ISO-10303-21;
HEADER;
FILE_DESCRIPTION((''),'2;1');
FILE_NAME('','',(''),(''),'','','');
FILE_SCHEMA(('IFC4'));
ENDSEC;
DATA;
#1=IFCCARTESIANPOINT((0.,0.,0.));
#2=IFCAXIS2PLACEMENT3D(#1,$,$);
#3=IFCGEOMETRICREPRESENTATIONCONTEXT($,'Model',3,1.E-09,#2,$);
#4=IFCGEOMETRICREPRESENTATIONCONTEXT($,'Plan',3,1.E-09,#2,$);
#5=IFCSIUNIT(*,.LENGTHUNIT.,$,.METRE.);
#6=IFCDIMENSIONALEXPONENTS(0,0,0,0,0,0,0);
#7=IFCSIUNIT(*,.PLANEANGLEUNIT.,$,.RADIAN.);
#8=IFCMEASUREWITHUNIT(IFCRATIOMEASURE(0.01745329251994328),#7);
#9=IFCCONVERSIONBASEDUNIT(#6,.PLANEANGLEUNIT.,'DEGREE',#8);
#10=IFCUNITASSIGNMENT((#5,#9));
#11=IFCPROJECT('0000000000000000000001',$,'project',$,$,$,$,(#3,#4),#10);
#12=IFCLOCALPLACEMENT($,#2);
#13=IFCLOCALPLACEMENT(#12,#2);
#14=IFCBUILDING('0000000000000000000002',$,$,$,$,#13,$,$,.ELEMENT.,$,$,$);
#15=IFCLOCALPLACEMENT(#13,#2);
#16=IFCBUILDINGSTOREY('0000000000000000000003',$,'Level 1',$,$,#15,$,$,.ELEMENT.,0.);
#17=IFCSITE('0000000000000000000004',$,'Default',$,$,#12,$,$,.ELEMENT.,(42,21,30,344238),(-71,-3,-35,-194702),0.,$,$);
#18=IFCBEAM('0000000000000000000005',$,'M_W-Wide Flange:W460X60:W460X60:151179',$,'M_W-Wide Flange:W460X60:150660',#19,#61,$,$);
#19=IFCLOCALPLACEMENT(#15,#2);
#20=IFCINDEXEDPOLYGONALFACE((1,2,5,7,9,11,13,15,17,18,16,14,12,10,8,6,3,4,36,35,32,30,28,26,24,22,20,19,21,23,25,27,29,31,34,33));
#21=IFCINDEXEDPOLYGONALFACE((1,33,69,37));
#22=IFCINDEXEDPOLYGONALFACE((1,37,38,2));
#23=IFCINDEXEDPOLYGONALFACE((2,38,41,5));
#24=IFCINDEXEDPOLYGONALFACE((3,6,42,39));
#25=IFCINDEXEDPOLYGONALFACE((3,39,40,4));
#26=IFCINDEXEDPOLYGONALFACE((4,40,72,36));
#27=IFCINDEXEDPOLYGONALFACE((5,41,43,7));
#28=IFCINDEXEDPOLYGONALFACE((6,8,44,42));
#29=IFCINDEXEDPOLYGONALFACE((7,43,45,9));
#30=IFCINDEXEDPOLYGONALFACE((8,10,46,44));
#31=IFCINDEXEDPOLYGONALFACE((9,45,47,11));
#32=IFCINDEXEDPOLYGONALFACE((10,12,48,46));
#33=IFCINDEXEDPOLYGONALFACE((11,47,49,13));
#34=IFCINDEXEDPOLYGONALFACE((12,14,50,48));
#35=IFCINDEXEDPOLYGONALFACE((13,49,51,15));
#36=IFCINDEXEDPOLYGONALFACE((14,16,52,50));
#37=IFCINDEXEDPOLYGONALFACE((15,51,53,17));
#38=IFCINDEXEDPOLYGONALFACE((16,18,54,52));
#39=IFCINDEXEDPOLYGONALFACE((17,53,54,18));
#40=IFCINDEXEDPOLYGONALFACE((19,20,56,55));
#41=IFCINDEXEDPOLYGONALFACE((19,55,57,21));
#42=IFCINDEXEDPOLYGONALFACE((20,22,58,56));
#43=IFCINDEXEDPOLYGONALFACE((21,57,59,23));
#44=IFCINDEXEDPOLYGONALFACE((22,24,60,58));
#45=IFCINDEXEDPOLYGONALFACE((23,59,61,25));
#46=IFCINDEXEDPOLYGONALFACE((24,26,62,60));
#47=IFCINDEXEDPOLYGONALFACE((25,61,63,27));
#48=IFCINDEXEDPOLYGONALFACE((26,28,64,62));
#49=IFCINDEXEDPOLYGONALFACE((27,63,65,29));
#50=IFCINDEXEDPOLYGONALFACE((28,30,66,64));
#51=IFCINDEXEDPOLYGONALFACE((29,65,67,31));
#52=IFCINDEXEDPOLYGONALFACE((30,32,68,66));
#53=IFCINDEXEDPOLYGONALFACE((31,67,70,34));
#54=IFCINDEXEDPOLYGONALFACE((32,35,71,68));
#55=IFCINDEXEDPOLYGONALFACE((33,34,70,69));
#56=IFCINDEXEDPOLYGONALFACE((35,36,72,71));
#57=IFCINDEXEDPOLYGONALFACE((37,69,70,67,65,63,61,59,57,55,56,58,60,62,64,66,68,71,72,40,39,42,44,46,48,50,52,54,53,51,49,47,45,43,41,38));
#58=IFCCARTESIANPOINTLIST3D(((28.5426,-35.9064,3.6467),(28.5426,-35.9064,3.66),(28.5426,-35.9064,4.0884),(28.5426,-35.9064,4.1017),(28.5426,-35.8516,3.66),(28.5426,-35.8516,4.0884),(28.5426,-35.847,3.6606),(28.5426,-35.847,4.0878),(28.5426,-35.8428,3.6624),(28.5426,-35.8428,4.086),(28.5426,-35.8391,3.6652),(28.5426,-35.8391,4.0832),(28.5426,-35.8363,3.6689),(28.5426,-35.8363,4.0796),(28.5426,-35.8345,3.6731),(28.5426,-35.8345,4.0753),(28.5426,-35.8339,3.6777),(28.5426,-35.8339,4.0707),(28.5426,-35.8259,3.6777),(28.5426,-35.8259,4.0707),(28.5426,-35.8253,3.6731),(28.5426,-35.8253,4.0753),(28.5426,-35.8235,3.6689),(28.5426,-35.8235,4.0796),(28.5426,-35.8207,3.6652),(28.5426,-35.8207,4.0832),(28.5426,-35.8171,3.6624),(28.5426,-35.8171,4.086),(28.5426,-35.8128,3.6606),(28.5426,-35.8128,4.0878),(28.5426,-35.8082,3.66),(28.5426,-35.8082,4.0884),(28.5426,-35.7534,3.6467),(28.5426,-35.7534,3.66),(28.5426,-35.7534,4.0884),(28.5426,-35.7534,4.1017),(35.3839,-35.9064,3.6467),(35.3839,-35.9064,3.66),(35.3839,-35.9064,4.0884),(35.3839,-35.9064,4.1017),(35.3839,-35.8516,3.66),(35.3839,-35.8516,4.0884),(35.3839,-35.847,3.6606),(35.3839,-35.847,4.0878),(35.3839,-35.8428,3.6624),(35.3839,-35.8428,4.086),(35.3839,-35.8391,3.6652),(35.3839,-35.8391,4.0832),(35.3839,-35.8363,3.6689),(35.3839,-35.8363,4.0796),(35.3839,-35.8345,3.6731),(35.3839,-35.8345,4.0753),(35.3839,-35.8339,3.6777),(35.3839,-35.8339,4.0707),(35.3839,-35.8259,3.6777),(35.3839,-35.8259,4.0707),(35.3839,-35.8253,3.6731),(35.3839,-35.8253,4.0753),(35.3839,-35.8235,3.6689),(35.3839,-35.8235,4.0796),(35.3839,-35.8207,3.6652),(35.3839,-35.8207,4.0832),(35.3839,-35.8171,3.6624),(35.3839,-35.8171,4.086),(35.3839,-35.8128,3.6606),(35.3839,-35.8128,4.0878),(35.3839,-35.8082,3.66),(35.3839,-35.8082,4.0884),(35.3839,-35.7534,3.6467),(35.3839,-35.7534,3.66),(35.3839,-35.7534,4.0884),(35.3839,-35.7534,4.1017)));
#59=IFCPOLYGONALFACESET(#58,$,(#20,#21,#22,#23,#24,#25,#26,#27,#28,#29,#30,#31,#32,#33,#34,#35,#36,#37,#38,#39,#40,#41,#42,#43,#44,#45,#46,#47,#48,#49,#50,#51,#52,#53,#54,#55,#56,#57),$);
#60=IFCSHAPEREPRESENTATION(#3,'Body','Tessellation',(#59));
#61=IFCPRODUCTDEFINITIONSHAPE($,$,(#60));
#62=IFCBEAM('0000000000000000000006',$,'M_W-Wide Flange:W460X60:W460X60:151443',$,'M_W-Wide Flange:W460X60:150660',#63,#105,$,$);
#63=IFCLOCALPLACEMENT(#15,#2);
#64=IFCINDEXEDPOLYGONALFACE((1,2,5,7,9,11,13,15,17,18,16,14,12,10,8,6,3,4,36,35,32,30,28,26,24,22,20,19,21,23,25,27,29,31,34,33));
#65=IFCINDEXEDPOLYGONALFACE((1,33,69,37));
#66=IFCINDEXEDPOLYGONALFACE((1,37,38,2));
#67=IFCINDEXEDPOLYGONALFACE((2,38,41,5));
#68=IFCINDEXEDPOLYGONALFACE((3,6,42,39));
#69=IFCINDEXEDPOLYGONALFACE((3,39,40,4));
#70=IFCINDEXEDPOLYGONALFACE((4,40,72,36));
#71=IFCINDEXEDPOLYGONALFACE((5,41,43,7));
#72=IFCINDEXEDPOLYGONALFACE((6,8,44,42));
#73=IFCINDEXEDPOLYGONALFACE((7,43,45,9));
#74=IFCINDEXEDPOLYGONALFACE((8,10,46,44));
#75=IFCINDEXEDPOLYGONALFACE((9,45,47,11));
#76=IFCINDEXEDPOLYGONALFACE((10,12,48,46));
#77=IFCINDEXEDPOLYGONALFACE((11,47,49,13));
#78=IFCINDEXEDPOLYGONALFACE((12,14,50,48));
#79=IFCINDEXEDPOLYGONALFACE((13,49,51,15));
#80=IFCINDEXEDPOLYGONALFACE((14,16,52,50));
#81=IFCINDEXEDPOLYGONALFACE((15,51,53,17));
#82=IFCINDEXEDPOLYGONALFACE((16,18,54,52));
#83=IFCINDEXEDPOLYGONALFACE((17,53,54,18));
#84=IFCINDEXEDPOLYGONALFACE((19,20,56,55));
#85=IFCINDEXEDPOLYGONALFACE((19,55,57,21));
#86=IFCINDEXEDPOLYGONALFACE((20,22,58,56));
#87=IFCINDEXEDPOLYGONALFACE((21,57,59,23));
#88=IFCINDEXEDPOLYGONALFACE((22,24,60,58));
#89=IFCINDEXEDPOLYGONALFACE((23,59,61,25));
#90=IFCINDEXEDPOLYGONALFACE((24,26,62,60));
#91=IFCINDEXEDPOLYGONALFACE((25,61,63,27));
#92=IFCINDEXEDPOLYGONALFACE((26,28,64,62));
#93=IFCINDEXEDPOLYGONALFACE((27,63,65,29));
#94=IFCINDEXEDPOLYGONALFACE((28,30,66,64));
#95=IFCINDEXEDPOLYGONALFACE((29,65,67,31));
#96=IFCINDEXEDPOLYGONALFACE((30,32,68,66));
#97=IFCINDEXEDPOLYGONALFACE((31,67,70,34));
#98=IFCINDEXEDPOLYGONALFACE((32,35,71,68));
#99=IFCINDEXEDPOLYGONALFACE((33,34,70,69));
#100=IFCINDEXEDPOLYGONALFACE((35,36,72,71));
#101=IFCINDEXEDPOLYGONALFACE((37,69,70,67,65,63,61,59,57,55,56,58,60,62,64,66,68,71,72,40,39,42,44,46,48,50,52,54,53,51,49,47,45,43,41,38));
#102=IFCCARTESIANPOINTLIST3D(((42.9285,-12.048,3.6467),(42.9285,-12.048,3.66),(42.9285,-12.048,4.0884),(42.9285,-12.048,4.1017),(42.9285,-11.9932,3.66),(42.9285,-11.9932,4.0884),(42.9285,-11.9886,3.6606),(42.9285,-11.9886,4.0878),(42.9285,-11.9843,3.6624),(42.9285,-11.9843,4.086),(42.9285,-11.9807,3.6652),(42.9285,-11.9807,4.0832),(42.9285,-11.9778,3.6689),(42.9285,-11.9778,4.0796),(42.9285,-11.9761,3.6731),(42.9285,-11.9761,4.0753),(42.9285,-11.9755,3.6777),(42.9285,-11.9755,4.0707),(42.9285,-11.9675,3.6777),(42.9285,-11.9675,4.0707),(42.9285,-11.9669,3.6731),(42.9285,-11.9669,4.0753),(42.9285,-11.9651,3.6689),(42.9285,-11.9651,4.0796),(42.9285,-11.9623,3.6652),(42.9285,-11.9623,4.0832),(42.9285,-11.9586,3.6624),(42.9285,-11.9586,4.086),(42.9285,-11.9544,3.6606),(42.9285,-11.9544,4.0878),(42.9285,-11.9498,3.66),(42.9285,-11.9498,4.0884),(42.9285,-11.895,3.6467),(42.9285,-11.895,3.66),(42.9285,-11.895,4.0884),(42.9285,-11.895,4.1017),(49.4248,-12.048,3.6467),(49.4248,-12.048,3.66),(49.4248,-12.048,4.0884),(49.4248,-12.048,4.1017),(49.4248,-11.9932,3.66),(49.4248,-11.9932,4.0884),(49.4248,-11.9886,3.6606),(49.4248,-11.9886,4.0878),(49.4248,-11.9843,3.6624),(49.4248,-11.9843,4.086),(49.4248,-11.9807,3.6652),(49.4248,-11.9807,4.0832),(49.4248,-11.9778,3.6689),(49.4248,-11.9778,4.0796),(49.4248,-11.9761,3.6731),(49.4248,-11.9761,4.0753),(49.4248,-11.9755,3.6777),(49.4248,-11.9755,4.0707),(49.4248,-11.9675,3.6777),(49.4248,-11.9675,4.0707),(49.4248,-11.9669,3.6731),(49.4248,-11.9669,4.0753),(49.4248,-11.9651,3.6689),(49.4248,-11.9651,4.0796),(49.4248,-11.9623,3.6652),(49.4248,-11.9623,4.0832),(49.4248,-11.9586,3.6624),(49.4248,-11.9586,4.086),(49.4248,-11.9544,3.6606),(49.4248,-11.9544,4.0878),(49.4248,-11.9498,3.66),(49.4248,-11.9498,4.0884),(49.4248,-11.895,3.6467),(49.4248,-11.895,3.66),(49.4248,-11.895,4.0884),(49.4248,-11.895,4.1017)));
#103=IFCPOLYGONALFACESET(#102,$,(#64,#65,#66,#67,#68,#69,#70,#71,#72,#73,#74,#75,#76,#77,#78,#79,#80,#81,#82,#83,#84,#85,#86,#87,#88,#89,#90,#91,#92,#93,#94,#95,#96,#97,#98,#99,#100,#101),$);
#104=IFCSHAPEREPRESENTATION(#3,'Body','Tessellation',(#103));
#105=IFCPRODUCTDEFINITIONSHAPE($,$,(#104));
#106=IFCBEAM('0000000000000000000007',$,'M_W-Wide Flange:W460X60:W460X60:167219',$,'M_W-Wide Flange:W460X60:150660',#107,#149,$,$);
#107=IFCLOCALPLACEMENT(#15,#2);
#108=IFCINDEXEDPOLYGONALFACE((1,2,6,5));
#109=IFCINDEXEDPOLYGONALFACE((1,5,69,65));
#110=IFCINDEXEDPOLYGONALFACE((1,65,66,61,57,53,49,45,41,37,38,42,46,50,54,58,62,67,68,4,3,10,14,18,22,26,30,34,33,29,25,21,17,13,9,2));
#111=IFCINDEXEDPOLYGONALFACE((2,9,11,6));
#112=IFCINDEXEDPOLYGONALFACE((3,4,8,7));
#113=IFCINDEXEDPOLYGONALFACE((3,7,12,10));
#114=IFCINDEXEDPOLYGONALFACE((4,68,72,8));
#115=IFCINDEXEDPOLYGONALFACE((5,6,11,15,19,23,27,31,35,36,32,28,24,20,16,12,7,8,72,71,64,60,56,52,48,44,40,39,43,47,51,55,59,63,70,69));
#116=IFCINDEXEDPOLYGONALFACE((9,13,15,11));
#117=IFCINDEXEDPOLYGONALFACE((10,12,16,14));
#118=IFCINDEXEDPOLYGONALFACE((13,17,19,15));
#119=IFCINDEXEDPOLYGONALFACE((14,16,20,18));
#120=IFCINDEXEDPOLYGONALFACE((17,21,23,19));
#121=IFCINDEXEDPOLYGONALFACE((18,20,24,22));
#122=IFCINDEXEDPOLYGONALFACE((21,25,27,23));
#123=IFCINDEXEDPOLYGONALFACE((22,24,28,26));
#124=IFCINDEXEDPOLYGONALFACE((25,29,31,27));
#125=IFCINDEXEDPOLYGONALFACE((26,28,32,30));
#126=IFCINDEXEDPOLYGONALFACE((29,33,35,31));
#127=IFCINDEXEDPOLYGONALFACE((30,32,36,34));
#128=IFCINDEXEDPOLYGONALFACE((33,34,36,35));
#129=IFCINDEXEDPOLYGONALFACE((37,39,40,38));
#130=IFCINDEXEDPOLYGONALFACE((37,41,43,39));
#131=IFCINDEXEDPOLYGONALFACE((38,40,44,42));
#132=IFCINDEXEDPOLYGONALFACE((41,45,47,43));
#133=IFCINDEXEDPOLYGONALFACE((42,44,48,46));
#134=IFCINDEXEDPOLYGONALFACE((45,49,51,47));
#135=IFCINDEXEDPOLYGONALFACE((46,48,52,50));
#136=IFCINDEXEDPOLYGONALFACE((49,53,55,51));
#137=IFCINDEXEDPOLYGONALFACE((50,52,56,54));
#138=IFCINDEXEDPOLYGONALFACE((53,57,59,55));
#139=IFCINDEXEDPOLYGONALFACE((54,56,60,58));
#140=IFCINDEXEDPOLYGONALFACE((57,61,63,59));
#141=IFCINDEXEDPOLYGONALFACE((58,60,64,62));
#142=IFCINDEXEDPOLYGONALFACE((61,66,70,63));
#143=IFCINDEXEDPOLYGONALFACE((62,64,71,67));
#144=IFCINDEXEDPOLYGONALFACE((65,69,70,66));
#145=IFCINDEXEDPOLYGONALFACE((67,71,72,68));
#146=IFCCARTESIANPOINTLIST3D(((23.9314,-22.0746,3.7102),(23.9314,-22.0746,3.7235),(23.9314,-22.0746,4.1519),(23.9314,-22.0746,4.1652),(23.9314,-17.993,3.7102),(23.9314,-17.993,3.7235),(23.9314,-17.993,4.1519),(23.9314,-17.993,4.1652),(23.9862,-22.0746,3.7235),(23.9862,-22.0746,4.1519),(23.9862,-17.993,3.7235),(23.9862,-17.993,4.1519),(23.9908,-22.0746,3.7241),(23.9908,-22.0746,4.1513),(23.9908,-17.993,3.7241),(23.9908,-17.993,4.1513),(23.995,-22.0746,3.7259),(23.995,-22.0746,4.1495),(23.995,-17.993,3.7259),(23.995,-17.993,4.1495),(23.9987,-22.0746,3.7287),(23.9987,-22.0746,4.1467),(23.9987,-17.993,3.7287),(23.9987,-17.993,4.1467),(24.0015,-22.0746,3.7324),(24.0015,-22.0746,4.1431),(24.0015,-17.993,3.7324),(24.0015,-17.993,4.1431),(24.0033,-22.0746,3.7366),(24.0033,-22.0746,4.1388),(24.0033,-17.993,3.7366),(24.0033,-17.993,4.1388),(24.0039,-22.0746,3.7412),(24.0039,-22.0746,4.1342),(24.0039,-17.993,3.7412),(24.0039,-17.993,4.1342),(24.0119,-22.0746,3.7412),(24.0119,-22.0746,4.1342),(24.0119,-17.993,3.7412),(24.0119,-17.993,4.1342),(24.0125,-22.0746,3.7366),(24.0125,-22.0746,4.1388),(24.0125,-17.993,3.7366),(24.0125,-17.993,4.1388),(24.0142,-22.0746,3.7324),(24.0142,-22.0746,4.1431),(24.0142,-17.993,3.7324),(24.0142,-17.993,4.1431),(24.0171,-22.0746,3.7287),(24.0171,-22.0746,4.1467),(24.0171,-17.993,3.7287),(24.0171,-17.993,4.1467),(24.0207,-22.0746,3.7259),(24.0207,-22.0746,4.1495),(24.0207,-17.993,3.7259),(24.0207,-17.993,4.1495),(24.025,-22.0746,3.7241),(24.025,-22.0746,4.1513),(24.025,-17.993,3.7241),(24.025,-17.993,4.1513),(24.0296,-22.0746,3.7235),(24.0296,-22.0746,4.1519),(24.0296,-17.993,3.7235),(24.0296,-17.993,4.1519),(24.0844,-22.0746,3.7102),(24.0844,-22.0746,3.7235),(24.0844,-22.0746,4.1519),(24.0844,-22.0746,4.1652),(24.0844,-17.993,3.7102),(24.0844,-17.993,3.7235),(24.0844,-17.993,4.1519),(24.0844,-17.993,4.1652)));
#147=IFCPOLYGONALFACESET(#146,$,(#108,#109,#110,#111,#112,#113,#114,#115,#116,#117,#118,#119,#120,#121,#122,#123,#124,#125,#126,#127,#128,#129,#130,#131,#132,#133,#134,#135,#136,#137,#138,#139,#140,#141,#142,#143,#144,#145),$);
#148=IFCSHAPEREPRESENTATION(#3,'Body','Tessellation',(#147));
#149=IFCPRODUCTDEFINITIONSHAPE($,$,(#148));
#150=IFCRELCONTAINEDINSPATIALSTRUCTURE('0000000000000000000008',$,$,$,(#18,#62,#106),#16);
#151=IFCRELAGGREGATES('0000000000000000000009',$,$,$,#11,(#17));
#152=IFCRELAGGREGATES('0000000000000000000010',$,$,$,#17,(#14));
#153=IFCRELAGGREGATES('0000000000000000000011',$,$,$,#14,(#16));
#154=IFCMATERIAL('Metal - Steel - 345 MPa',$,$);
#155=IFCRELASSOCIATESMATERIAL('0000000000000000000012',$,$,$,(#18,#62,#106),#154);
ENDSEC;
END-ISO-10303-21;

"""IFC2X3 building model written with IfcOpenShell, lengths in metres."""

from ifc_helpers import new_model, entity, si_unit, converted_unit, frame, frame_2d, origin, place, context, project, spatial, polyline, circle_curve, parameter, trimmed, segment, composite_curve, outline, extrude, material, element, save


model = new_model("IFC2X3")

# Units and contexts
model_context = context("Model", 3, precision=1e-09, world=origin())
plan_context = context("Plan", 3, precision=1e-09, world=origin())
ifc_project = project(units=[si_unit("LENGTHUNIT", "METRE"), converted_unit("PLANEANGLEUNIT", "DEGREE", entity("IfcRatioMeasure", 0.01745329251994328), si_unit("PLANEANGLEUNIT", "RADIAN"), dimensions=[0, 0, 0, 0, 0, 0, 0])], contexts=[model_context, plan_context])

# Site, building, storey
site_placement = place(None, origin())
site = spatial("IfcSite", under=ifc_project, at=site_placement, Name="Default", CompositionType="ELEMENT", RefLatitude=(42, 21, 30, 344238), RefLongitude=(-71, -3, -35, -194702), RefElevation=0.0)
building_placement = place(site_placement, origin())
building = spatial("IfcBuilding", under=site, at=building_placement, CompositionType="ELEMENT")
storey_placement = place(building_placement, origin())
storey = spatial("IfcBuildingStorey", under=building, at=storey_placement, Name="Level 1", CompositionType="ELEMENT", Elevation=0.0)

# Beams
ifc_material = material(Name="Metal - Steel - 345 MPa")
beam_1_placement = place(storey_placement, frame((35.4986, -35.8299, 4.2672), z_axis=(0.0, 0.0, 1.0), x_axis=(0.0, 1.0, 0.0)))
element("IfcBeam", 1, at=beam_1_placement, inside=storey, material=ifc_material, Name="M_W-Wide Flange:W460X60:W460X60:151179", ObjectType="M_W-Wide Flange:W460X60:150660", context=model_context, shape_type="SweptSolid", body=[
    extrude(outline(composite_curve([segment(polyline([(0.2142, -0.0765), (0.2275, -0.0765)]), True, "CONTINUOUS"), segment(polyline([(0.2275, -0.0765), (0.2275, 0.0765)]), True, "CONTINUOUS"), segment(polyline([(0.2275, 0.0765), (0.2142, 0.0765)]), True, "CONTINUOUS"), segment(polyline([(0.2142, 0.0765), (0.2142, 0.0217)]), True, "CONTINUOUS"), segment(trimmed(circle_curve(frame_2d((0.1965, 0.0217), x_axis=(1.0, 0.0)), 0.0177), [parameter(270.0)], [parameter(360.0)], True, "PARAMETER"), False, "CONTINUOUS"), segment(polyline([(0.1965, 0.004), (-0.1965, 0.004)]), True, "CONTINUOUS"), segment(trimmed(circle_curve(frame_2d((-0.1965, 0.0217), x_axis=(0.0, -1.0)), 0.0177), [parameter(270.0)], [parameter(360.0)], True, "PARAMETER"), False, "CONTINUOUS"), segment(polyline([(-0.2142, 0.0217), (-0.2142, 0.0765)]), True, "CONTINUOUS"), segment(polyline([(-0.2142, 0.0765), (-0.2275, 0.0765)]), True, "CONTINUOUS"), segment(polyline([(-0.2275, 0.0765), (-0.2275, -0.0765)]), True, "CONTINUOUS"), segment(polyline([(-0.2275, -0.0765), (-0.2142, -0.0765)]), True, "CONTINUOUS"), segment(polyline([(-0.2142, -0.0765), (-0.2142, -0.0217)]), True, "CONTINUOUS"), segment(trimmed(circle_curve(frame_2d((-0.1965, -0.0217), x_axis=(-1.0, 0.0)), 0.0177), [parameter(270.0)], [parameter(360.0)], True, "PARAMETER"), False, "CONTINUOUS"), segment(polyline([(-0.1965, -0.004), (0.1965, -0.004)]), True, "CONTINUOUS"), segment(trimmed(circle_curve(frame_2d((0.1965, -0.0217), x_axis=(0.0, 1.0)), 0.0177), [parameter(270.0)], [parameter(0.0)], True, "PARAMETER"), False, "CONTINUOUS"), segment(polyline([(0.2142, -0.0217), (0.2142, -0.0765)]), True, "CONTINUOUS")], self_intersect=False)), frame((0.0, 6.9561, -0.393), z_axis=(0.0, -1.0, 0.0), x_axis=(0.0, 0.0, -1.0)), (0.0, 0.0, 1.0), 6.8414),
])
beam_2_placement = place(storey_placement, frame((42.8138, -11.9715, 4.2672), z_axis=(0.0, 0.0, 1.0), x_axis=(0.0, -1.0, 0.0)))
element("IfcBeam", 2, at=beam_2_placement, inside=storey, material=ifc_material, Name="M_W-Wide Flange:W460X60:W460X60:151443", ObjectType="M_W-Wide Flange:W460X60:150660", context=model_context, shape_type="SweptSolid", body=[
    extrude(outline(composite_curve([segment(polyline([(-0.0765, -0.2142), (-0.0765, -0.2275)]), True, "CONTINUOUS"), segment(polyline([(-0.0765, -0.2275), (0.0765, -0.2275)]), True, "CONTINUOUS"), segment(polyline([(0.0765, -0.2275), (0.0765, -0.2142)]), True, "CONTINUOUS"), segment(polyline([(0.0765, -0.2142), (0.0217, -0.2142)]), True, "CONTINUOUS"), segment(trimmed(circle_curve(frame_2d((0.0217, -0.1965), x_axis=(1.0, 0.0)), 0.0177), [parameter(180.0)], [parameter(270.0)], True, "PARAMETER"), False, "CONTINUOUS"), segment(polyline([(0.004, -0.1965), (0.004, 0.1965)]), True, "CONTINUOUS"), segment(trimmed(circle_curve(frame_2d((0.0217, 0.1965), x_axis=(1.0, 0.0)), 0.0177), [parameter(90.0)], [parameter(180.0)], True, "PARAMETER"), False, "CONTINUOUS"), segment(polyline([(0.0217, 0.2142), (0.0765, 0.2142)]), True, "CONTINUOUS"), segment(polyline([(0.0765, 0.2142), (0.0765, 0.2275)]), True, "CONTINUOUS"), segment(polyline([(0.0765, 0.2275), (-0.0765, 0.2275)]), True, "CONTINUOUS"), segment(polyline([(-0.0765, 0.2275), (-0.0765, 0.2142)]), True, "CONTINUOUS"), segment(polyline([(-0.0765, 0.2142), (-0.0217, 0.2142)]), True, "CONTINUOUS"), segment(trimmed(circle_curve(frame_2d((-0.0217, 0.1965), x_axis=(1.0, 0.0)), 0.0177), [parameter(360.0)], [parameter(90.0)], True, "PARAMETER"), False, "CONTINUOUS"), segment(polyline([(-0.004, 0.1965), (-0.004, -0.1965)]), True, "CONTINUOUS"), segment(trimmed(circle_curve(frame_2d((-0.0217, -0.1965), x_axis=(1.0, 0.0)), 0.0177), [parameter(270.0)], [parameter(0.0)], True, "PARAMETER"), False, "CONTINUOUS"), segment(polyline([(-0.0217, -0.2142), (-0.0765, -0.2142)]), True, "CONTINUOUS")], self_intersect=False)), frame((0.0, 0.1147, -0.393), z_axis=(0.0, -1.0, 0.0), x_axis=(1.0, 0.0, 0.0)), (0.0, 0.0, -1.0), 6.4963),
])
beam_3_placement = place(storey_placement, frame((24.0079, -17.9038, 4.2672), z_axis=(0.0, 0.0, 1.0), x_axis=(-1.0, 0.0, 0.0)))
element("IfcBeam", 3, at=beam_3_placement, inside=storey, material=ifc_material, Name="M_W-Wide Flange:W460X60:W460X60:167219", ObjectType="M_W-Wide Flange:W460X60:150660", context=model_context, shape_type="SweptSolid", body=[
    extrude(outline(composite_curve([segment(polyline([(0.2142, -0.0765), (0.2275, -0.0765)]), True, "CONTINUOUS"), segment(polyline([(0.2275, -0.0765), (0.2275, 0.0765)]), True, "CONTINUOUS"), segment(polyline([(0.2275, 0.0765), (0.2142, 0.0765)]), True, "CONTINUOUS"), segment(polyline([(0.2142, 0.0765), (0.2142, 0.0217)]), True, "CONTINUOUS"), segment(trimmed(circle_curve(frame_2d((0.1965, 0.0217), x_axis=(1.0, 0.0)), 0.0177), [parameter(270.0)], [parameter(360.0)], True, "PARAMETER"), False, "CONTINUOUS"), segment(polyline([(0.1965, 0.004), (-0.1965, 0.004)]), True, "CONTINUOUS"), segment(trimmed(circle_curve(frame_2d((-0.1965, 0.0217), x_axis=(0.0, -1.0)), 0.0177), [parameter(270.0)], [parameter(360.0)], True, "PARAMETER"), False, "CONTINUOUS"), segment(polyline([(-0.2142, 0.0217), (-0.2142, 0.0765)]), True, "CONTINUOUS"), segment(polyline([(-0.2142, 0.0765), (-0.2275, 0.0765)]), True, "CONTINUOUS"), segment(polyline([(-0.2275, 0.0765), (-0.2275, -0.0765)]), True, "CONTINUOUS"), segment(polyline([(-0.2275, -0.0765), (-0.2142, -0.0765)]), True, "CONTINUOUS"), segment(polyline([(-0.2142, -0.0765), (-0.2142, -0.0217)]), True, "CONTINUOUS"), segment(trimmed(circle_curve(frame_2d((-0.1965, -0.0217), x_axis=(-1.0, 0.0)), 0.0177), [parameter(270.0)], [parameter(360.0)], True, "PARAMETER"), False, "CONTINUOUS"), segment(polyline([(-0.1965, -0.004), (0.1965, -0.004)]), True, "CONTINUOUS"), segment(trimmed(circle_curve(frame_2d((0.1965, -0.0217), x_axis=(0.0, 1.0)), 0.0177), [parameter(270.0)], [parameter(0.0)], True, "PARAMETER"), False, "CONTINUOUS"), segment(polyline([(0.2142, -0.0217), (0.2142, -0.0765)]), True, "CONTINUOUS")], self_intersect=False)), frame((0.0, 4.1708, -0.3295), z_axis=(0.0, -1.0, 0.0), x_axis=(0.0, 0.0, -1.0)), (0.0, 0.0, 1.0), 4.0816),
])

save(model, "model.ifc")
